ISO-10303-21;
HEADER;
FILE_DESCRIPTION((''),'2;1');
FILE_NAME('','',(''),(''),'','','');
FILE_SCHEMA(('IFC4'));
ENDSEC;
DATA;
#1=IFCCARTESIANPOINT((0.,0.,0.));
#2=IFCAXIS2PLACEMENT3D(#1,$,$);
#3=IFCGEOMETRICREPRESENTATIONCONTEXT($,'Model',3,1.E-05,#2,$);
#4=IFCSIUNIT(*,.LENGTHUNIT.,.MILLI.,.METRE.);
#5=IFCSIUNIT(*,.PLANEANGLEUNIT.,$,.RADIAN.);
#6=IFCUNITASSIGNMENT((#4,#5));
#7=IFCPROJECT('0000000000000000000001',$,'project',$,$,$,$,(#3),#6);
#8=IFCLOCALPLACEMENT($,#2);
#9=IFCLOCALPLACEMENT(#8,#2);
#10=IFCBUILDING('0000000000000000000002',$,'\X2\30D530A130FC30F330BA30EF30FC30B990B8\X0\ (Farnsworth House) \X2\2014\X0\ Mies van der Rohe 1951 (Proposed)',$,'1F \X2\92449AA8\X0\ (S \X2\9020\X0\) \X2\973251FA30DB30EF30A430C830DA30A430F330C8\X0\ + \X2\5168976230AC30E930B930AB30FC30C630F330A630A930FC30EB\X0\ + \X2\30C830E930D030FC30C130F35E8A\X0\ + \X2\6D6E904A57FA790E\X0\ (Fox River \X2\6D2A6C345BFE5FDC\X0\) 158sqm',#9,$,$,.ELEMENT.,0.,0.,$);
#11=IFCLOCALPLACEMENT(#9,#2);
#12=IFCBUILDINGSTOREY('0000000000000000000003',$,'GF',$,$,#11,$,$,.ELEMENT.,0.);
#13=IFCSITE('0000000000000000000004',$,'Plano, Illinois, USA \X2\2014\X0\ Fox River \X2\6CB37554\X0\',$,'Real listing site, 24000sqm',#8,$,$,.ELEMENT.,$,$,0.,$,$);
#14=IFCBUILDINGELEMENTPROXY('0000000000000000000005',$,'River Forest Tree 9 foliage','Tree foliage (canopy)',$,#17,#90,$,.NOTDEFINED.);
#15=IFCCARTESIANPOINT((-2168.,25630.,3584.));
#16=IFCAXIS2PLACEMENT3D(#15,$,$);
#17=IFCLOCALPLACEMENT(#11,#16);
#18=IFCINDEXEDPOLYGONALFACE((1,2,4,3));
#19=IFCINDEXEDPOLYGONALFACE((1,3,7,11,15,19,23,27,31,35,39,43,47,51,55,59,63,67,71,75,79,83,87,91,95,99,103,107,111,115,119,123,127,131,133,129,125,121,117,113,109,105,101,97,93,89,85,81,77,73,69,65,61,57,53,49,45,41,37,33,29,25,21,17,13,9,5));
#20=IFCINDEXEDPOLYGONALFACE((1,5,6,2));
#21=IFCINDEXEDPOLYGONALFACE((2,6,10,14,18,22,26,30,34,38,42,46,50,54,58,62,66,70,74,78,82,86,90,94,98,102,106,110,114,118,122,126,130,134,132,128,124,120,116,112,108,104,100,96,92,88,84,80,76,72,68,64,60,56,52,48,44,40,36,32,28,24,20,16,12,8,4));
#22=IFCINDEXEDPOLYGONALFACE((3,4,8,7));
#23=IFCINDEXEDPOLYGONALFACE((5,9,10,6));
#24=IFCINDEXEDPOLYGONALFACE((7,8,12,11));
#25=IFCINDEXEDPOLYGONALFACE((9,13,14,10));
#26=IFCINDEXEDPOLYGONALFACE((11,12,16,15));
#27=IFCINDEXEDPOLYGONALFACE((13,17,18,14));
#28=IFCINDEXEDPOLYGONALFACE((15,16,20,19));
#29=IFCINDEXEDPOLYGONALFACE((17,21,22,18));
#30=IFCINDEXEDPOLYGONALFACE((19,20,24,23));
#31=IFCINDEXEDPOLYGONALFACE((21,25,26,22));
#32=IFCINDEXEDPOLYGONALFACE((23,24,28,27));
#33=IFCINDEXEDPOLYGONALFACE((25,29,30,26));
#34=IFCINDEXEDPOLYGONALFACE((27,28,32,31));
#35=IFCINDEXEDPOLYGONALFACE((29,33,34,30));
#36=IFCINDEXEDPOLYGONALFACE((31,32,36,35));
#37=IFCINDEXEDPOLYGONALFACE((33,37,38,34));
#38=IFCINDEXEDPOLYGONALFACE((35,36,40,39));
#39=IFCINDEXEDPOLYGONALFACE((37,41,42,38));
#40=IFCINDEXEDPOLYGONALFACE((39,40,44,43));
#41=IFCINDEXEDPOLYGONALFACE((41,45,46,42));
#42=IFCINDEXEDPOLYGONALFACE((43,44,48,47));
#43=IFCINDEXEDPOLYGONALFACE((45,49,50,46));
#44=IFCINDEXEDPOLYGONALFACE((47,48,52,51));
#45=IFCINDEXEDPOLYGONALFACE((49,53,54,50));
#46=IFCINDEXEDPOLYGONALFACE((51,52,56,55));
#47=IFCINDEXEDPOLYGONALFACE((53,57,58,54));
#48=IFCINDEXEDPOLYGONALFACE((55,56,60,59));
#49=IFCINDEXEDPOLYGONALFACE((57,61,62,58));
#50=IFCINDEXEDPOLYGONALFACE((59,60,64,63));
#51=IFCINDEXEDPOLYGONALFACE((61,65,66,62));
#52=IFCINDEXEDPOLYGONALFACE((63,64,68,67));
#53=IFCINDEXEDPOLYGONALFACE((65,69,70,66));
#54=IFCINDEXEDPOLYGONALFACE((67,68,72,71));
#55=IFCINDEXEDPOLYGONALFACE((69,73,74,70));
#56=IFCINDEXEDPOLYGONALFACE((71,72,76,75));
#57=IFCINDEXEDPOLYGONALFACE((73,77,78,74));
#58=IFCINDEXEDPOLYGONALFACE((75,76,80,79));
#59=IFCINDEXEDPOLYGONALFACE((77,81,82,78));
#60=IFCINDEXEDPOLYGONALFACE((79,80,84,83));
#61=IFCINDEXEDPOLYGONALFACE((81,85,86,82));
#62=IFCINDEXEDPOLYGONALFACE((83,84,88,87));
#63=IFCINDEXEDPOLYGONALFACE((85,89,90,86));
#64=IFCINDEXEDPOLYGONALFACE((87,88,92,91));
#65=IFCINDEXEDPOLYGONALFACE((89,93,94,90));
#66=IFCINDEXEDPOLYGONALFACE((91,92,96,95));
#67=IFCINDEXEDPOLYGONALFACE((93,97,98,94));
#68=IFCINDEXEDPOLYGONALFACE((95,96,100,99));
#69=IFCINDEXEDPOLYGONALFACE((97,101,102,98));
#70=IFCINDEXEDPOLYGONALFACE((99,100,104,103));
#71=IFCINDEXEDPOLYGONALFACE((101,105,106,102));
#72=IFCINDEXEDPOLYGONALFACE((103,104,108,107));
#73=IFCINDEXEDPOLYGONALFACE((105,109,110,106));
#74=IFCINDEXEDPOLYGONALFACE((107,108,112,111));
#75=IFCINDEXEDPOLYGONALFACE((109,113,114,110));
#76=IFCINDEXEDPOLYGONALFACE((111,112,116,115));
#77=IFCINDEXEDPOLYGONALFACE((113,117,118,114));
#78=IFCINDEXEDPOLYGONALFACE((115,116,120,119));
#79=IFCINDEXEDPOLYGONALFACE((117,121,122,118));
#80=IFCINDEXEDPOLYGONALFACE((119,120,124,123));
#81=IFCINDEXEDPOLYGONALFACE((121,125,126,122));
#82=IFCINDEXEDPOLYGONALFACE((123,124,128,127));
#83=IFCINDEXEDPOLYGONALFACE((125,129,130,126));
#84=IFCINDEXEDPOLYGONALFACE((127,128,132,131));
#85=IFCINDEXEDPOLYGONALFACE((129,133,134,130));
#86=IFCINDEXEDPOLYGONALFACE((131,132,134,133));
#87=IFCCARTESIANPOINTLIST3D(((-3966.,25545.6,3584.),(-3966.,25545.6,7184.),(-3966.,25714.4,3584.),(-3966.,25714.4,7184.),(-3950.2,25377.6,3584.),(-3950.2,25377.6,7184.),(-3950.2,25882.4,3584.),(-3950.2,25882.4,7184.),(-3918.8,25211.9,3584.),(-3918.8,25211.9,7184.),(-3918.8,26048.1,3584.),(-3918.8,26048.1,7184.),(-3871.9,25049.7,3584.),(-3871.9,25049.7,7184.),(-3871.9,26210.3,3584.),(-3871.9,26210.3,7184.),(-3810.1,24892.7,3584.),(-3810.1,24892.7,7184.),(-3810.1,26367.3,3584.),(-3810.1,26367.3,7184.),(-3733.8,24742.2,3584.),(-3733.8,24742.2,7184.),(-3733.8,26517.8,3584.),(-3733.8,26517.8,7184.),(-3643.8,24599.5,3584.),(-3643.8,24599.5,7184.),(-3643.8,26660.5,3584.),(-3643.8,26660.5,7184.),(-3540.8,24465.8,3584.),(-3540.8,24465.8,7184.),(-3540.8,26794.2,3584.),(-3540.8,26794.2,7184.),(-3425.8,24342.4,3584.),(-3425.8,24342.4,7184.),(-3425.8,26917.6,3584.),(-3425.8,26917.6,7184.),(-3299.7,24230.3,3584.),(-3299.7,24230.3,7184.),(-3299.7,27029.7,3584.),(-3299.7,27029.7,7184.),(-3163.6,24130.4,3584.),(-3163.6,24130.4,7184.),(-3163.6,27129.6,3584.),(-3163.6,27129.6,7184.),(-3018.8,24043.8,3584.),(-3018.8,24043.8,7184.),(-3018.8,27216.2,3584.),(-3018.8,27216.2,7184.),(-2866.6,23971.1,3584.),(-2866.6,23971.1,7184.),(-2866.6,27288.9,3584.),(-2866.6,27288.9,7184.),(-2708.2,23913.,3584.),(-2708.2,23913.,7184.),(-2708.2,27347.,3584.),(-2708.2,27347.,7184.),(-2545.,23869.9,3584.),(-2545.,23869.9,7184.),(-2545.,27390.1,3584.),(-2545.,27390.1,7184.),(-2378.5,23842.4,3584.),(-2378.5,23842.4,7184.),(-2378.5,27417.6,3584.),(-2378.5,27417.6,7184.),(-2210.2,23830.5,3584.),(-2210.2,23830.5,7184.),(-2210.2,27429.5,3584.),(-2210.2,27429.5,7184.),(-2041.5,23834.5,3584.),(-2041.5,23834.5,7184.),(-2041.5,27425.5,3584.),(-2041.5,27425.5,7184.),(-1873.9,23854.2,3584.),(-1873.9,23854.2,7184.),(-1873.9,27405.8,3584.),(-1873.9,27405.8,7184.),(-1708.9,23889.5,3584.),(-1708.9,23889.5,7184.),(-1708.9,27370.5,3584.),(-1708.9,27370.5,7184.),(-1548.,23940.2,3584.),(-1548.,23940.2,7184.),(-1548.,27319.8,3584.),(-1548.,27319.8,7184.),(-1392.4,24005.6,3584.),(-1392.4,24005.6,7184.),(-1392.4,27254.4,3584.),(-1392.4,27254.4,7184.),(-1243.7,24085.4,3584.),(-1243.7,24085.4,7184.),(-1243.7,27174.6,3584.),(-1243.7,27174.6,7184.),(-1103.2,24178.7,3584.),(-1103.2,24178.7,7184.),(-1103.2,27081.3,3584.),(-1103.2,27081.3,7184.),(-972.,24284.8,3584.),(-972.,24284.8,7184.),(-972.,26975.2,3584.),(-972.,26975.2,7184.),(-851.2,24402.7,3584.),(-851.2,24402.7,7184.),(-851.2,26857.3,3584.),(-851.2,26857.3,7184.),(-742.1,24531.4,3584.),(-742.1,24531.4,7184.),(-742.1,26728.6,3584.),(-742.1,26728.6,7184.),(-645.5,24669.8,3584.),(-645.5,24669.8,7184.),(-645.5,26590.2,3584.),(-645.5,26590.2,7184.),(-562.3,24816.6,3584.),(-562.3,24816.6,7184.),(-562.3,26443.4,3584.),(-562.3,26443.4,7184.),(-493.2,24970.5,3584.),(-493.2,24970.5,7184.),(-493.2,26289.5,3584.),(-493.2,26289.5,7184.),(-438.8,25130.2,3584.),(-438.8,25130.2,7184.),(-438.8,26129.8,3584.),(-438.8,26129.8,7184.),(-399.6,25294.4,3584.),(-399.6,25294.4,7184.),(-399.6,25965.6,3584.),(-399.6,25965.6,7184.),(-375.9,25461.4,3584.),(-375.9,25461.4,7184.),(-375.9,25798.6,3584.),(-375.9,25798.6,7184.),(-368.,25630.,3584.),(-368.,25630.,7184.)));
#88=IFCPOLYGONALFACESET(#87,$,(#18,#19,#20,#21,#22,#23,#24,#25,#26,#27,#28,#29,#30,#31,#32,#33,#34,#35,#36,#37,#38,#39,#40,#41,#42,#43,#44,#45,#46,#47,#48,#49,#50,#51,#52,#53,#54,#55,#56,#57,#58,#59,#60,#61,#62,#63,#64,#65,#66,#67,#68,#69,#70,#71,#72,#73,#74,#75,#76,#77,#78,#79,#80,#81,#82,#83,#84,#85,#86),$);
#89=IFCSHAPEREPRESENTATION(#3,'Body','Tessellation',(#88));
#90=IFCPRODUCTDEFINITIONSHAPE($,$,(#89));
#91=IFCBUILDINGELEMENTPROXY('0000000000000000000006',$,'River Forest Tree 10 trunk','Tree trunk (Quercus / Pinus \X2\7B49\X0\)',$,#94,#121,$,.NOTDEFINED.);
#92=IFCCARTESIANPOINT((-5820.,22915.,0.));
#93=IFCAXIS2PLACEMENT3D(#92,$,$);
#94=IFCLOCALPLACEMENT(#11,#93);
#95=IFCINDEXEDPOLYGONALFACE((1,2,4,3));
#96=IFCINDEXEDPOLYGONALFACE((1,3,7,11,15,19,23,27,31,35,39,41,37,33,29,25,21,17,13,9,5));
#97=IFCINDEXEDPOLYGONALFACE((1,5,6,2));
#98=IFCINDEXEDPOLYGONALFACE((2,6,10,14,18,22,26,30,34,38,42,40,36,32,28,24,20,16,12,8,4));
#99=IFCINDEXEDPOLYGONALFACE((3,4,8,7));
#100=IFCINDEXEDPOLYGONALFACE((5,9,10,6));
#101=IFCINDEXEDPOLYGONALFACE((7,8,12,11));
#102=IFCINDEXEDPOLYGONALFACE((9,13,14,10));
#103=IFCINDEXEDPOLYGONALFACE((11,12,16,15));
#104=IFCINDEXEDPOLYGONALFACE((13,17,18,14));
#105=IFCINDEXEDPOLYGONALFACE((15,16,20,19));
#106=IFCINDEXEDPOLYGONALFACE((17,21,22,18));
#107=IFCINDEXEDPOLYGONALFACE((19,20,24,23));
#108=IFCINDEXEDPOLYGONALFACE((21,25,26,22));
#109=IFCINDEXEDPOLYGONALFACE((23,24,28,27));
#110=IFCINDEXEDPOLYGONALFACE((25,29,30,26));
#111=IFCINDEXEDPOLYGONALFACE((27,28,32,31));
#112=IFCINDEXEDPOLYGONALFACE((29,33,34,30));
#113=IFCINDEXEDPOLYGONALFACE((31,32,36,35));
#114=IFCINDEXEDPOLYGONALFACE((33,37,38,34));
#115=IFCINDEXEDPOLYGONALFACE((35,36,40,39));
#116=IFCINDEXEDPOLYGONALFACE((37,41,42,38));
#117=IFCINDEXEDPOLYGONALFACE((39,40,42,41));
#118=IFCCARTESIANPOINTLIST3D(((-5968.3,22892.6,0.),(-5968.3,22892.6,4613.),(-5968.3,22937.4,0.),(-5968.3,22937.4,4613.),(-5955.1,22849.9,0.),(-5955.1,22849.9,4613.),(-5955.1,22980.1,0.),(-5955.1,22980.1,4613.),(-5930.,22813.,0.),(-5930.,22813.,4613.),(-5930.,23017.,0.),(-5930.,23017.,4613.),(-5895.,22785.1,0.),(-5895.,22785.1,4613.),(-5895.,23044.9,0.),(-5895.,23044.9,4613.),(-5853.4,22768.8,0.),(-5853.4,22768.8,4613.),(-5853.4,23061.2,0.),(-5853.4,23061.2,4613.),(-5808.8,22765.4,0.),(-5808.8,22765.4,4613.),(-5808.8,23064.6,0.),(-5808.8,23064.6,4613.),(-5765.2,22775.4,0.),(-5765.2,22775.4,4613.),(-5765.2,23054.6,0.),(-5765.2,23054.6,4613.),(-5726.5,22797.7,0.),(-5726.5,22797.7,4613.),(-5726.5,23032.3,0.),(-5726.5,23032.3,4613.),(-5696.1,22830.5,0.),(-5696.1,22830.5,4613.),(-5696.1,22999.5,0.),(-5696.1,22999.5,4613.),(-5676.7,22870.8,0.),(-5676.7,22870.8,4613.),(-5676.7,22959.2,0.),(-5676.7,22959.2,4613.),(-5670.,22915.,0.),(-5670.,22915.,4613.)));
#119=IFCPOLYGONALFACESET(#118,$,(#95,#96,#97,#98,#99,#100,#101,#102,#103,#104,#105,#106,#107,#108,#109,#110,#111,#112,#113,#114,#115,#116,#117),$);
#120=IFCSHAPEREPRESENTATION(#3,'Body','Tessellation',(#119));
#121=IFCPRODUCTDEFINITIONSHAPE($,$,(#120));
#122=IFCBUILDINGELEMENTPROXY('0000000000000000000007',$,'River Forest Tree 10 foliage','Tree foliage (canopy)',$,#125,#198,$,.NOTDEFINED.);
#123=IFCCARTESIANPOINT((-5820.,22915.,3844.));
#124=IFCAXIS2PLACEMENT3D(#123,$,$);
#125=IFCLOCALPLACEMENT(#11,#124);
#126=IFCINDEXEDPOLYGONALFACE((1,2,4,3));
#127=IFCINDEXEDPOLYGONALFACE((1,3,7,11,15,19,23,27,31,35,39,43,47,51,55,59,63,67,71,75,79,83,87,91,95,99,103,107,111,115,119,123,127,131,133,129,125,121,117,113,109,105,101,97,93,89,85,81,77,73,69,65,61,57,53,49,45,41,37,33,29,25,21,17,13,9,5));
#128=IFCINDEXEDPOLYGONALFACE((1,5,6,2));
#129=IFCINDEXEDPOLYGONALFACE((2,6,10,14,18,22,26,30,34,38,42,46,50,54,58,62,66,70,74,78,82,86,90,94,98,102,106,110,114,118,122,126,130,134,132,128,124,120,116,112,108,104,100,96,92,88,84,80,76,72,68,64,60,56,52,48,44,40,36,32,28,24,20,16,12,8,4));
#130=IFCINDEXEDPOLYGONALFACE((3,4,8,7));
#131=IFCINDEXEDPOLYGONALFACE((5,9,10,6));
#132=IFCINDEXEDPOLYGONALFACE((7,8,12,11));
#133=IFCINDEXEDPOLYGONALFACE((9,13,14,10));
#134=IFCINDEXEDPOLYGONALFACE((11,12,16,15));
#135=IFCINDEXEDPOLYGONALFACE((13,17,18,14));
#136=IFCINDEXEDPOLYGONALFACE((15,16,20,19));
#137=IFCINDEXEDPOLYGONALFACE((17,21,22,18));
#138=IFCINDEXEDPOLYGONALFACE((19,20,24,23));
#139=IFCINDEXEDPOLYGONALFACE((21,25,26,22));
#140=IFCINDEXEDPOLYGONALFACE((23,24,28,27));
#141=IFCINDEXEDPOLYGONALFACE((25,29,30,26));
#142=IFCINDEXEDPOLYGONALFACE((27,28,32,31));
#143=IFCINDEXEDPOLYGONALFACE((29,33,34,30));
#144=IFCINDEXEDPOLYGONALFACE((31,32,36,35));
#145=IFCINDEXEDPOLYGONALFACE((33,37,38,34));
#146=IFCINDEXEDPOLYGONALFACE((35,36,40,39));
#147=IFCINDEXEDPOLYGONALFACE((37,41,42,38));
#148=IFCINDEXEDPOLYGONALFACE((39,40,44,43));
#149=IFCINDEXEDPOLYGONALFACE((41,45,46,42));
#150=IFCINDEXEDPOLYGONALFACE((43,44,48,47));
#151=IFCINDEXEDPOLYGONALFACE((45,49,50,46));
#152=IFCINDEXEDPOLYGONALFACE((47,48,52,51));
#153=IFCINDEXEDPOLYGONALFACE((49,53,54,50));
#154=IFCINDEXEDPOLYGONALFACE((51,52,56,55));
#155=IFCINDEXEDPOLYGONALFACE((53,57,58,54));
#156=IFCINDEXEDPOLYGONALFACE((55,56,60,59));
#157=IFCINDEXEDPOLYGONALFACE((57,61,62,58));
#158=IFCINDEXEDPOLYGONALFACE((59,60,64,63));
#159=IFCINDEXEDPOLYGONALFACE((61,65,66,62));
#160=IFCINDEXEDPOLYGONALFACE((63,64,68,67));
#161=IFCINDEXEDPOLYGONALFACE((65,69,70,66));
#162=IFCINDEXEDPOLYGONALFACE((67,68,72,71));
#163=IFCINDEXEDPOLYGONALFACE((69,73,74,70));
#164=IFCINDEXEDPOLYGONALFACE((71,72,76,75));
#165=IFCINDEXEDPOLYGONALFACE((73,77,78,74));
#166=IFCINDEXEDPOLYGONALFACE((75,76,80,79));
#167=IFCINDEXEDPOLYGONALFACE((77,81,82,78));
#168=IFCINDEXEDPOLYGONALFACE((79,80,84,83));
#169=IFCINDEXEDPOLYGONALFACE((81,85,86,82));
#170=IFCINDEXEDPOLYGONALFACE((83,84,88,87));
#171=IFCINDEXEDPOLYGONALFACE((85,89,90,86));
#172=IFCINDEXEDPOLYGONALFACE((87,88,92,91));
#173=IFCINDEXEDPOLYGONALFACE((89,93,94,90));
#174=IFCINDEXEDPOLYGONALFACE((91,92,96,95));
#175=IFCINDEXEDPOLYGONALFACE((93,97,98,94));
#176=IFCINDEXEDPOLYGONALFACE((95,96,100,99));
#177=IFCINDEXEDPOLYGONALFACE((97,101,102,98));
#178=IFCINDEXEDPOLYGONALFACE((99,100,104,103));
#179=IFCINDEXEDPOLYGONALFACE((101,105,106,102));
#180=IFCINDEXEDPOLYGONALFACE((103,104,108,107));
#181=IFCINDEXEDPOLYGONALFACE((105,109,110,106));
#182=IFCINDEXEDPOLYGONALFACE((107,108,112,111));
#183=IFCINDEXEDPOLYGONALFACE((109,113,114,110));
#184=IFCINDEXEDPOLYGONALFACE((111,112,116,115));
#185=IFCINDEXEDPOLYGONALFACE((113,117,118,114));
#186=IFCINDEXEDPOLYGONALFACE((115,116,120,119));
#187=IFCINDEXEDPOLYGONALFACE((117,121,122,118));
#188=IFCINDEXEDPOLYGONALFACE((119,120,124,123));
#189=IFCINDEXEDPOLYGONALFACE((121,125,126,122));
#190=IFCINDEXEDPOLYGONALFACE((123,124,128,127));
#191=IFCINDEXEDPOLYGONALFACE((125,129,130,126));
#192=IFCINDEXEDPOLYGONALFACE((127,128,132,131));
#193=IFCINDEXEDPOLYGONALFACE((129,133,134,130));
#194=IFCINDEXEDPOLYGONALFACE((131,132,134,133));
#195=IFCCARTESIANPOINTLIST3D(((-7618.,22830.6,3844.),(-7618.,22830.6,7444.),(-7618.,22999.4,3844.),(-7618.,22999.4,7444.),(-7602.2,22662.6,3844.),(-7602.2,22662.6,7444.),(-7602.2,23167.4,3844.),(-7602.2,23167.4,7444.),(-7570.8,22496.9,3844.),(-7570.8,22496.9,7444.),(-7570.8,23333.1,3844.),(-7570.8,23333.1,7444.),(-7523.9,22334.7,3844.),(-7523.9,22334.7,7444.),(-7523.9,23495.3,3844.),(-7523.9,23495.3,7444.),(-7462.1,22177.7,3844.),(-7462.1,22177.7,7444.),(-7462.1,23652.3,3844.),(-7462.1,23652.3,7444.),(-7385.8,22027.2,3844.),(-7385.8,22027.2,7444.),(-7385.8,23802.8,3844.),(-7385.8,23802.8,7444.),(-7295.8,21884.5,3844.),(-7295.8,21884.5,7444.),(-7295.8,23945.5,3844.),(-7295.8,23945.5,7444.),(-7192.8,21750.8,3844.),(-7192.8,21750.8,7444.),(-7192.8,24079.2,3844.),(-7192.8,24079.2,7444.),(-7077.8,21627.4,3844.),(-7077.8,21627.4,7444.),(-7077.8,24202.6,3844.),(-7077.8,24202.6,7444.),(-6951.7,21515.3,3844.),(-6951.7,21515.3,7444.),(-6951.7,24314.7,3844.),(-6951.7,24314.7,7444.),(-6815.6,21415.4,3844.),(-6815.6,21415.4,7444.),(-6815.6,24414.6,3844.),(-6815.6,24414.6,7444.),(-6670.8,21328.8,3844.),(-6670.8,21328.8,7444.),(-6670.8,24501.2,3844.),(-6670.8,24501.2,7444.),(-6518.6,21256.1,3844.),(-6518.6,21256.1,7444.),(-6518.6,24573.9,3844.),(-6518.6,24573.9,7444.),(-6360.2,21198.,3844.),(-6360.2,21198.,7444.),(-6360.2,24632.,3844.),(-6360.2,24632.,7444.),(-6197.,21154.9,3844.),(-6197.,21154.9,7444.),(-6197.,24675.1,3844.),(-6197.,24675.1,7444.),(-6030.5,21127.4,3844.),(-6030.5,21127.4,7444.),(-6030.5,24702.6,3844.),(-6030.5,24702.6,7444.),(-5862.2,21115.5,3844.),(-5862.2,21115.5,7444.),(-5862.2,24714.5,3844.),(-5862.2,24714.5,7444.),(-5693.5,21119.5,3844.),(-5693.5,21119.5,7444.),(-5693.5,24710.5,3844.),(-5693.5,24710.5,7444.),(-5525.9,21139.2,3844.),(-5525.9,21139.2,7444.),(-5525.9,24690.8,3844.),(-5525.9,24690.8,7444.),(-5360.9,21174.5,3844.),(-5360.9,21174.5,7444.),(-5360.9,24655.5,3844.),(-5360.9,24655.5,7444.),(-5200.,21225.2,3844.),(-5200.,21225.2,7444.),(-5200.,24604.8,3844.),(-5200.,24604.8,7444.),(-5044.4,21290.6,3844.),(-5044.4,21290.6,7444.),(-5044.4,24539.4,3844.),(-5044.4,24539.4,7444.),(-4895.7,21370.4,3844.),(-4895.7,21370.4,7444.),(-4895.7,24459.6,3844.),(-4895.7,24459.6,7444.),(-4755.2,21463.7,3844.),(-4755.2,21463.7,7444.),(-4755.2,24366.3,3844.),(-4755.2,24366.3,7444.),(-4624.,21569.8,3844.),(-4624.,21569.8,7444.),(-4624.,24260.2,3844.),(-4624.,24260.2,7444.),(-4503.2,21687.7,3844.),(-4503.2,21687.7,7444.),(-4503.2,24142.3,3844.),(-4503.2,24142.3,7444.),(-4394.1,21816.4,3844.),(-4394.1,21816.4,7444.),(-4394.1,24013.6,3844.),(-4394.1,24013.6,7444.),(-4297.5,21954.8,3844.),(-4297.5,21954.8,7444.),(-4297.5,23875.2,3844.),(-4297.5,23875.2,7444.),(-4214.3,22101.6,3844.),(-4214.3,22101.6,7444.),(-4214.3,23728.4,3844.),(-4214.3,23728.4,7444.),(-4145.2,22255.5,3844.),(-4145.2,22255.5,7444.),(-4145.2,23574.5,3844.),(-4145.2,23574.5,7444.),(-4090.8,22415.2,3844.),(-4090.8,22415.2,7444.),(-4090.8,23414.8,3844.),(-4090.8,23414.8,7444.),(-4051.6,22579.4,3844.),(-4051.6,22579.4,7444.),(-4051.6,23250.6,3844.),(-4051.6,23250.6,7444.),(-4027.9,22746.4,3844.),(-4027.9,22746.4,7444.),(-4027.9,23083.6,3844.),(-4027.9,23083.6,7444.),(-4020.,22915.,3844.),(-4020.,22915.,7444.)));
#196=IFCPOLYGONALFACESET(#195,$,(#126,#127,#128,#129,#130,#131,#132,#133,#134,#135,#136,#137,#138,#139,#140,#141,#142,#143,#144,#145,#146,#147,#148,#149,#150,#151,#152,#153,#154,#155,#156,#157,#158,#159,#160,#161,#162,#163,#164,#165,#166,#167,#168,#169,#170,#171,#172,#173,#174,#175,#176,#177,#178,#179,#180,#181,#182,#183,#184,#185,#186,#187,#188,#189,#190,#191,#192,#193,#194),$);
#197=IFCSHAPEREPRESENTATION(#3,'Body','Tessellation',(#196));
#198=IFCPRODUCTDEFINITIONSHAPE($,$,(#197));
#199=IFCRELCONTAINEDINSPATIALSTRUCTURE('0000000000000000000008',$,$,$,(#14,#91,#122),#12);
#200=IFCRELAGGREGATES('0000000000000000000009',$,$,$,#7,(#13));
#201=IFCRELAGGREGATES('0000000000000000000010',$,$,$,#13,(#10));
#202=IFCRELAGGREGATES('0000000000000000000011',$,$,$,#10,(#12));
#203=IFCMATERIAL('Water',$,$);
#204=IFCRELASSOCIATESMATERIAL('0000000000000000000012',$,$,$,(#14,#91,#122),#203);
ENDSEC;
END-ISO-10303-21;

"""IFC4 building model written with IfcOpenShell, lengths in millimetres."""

from ifc_helpers import new_model, si_unit, frame, origin, origin_2d, place, context, project, spatial, circle, extrude, material, element, save


model = new_model("IFC4")

# Units and contexts
model_context = context("Model", 3, precision=1e-05, world=origin())
ifc_project = project(units=[si_unit("LENGTHUNIT", "METRE", prefix="MILLI"), si_unit("PLANEANGLEUNIT", "RADIAN")], contexts=[model_context])

# Site, building, storey
site_placement = place(None, origin())
site = spatial("IfcSite", under=ifc_project, at=site_placement, Name="Plano, Illinois, USA — Fox River 河畔", ObjectType="Real listing site, 24000sqm", CompositionType="ELEMENT", RefElevation=0.0)
building_placement = place(site_placement, origin())
building = spatial("IfcBuilding", under=site, at=building_placement, Name="ファーンズワース邸 (Farnsworth House) — Mies van der Rohe 1951 (Proposed)", ObjectType="1F 鉄骨 (S 造) 露出ホワイトペイント + 全面ガラスカーテンウォール + トラバーチン床 + 浮遊基礎 (Fox River 洪水対応) 158sqm", CompositionType="ELEMENT", ElevationOfRefHeight=0.0, ElevationOfTerrain=0.0)
storey_placement = place(building_placement, origin())
storey = spatial("IfcBuildingStorey", under=building, at=storey_placement, Name="GF", CompositionType="ELEMENT", Elevation=0.0)

# Building element proxies
ifc_material_1 = material(Name="Water")
proxy_1_placement = place(storey_placement, frame((-2168.0, 25630.0, 3584.0)))
element("IfcBuildingElementProxy", 1, at=proxy_1_placement, inside=storey, material=ifc_material_1, Name="River Forest Tree 9 foliage", Description="Tree foliage (canopy)", PredefinedType="NOTDEFINED", context=model_context, shape_type="SweptSolid", body=[
    extrude(circle(Radius=1800.0, at=origin_2d()), frame((-2168.0, 25630.0, 3584.0)), (0.0, 0.0, 1.0), 3600.0),
])
proxy_2_placement = place(storey_placement, frame((-5820.0, 22915.0, 0.0)))
element("IfcBuildingElementProxy", 2, at=proxy_2_placement, inside=storey, material=ifc_material_1, Name="River Forest Tree 10 trunk", Description="Tree trunk (Quercus / Pinus 等)", PredefinedType="NOTDEFINED", context=model_context, shape_type="SweptSolid", body=[
    extrude(circle(Radius=150.0, at=origin_2d()), frame((-5820.0, 22915.0, 0.0)), (0.0, 0.0, 1.0), 4613.0),
])
proxy_3_placement = place(storey_placement, frame((-5820.0, 22915.0, 3844.0)))
element("IfcBuildingElementProxy", 3, at=proxy_3_placement, inside=storey, material=ifc_material_1, Name="River Forest Tree 10 foliage", Description="Tree foliage (canopy)", PredefinedType="NOTDEFINED", context=model_context, shape_type="SweptSolid", body=[
    extrude(circle(Radius=1800.0, at=origin_2d()), frame((-5820.0, 22915.0, 3844.0)), (0.0, 0.0, 1.0), 3600.0),
])

save(model, "model.ifc")
